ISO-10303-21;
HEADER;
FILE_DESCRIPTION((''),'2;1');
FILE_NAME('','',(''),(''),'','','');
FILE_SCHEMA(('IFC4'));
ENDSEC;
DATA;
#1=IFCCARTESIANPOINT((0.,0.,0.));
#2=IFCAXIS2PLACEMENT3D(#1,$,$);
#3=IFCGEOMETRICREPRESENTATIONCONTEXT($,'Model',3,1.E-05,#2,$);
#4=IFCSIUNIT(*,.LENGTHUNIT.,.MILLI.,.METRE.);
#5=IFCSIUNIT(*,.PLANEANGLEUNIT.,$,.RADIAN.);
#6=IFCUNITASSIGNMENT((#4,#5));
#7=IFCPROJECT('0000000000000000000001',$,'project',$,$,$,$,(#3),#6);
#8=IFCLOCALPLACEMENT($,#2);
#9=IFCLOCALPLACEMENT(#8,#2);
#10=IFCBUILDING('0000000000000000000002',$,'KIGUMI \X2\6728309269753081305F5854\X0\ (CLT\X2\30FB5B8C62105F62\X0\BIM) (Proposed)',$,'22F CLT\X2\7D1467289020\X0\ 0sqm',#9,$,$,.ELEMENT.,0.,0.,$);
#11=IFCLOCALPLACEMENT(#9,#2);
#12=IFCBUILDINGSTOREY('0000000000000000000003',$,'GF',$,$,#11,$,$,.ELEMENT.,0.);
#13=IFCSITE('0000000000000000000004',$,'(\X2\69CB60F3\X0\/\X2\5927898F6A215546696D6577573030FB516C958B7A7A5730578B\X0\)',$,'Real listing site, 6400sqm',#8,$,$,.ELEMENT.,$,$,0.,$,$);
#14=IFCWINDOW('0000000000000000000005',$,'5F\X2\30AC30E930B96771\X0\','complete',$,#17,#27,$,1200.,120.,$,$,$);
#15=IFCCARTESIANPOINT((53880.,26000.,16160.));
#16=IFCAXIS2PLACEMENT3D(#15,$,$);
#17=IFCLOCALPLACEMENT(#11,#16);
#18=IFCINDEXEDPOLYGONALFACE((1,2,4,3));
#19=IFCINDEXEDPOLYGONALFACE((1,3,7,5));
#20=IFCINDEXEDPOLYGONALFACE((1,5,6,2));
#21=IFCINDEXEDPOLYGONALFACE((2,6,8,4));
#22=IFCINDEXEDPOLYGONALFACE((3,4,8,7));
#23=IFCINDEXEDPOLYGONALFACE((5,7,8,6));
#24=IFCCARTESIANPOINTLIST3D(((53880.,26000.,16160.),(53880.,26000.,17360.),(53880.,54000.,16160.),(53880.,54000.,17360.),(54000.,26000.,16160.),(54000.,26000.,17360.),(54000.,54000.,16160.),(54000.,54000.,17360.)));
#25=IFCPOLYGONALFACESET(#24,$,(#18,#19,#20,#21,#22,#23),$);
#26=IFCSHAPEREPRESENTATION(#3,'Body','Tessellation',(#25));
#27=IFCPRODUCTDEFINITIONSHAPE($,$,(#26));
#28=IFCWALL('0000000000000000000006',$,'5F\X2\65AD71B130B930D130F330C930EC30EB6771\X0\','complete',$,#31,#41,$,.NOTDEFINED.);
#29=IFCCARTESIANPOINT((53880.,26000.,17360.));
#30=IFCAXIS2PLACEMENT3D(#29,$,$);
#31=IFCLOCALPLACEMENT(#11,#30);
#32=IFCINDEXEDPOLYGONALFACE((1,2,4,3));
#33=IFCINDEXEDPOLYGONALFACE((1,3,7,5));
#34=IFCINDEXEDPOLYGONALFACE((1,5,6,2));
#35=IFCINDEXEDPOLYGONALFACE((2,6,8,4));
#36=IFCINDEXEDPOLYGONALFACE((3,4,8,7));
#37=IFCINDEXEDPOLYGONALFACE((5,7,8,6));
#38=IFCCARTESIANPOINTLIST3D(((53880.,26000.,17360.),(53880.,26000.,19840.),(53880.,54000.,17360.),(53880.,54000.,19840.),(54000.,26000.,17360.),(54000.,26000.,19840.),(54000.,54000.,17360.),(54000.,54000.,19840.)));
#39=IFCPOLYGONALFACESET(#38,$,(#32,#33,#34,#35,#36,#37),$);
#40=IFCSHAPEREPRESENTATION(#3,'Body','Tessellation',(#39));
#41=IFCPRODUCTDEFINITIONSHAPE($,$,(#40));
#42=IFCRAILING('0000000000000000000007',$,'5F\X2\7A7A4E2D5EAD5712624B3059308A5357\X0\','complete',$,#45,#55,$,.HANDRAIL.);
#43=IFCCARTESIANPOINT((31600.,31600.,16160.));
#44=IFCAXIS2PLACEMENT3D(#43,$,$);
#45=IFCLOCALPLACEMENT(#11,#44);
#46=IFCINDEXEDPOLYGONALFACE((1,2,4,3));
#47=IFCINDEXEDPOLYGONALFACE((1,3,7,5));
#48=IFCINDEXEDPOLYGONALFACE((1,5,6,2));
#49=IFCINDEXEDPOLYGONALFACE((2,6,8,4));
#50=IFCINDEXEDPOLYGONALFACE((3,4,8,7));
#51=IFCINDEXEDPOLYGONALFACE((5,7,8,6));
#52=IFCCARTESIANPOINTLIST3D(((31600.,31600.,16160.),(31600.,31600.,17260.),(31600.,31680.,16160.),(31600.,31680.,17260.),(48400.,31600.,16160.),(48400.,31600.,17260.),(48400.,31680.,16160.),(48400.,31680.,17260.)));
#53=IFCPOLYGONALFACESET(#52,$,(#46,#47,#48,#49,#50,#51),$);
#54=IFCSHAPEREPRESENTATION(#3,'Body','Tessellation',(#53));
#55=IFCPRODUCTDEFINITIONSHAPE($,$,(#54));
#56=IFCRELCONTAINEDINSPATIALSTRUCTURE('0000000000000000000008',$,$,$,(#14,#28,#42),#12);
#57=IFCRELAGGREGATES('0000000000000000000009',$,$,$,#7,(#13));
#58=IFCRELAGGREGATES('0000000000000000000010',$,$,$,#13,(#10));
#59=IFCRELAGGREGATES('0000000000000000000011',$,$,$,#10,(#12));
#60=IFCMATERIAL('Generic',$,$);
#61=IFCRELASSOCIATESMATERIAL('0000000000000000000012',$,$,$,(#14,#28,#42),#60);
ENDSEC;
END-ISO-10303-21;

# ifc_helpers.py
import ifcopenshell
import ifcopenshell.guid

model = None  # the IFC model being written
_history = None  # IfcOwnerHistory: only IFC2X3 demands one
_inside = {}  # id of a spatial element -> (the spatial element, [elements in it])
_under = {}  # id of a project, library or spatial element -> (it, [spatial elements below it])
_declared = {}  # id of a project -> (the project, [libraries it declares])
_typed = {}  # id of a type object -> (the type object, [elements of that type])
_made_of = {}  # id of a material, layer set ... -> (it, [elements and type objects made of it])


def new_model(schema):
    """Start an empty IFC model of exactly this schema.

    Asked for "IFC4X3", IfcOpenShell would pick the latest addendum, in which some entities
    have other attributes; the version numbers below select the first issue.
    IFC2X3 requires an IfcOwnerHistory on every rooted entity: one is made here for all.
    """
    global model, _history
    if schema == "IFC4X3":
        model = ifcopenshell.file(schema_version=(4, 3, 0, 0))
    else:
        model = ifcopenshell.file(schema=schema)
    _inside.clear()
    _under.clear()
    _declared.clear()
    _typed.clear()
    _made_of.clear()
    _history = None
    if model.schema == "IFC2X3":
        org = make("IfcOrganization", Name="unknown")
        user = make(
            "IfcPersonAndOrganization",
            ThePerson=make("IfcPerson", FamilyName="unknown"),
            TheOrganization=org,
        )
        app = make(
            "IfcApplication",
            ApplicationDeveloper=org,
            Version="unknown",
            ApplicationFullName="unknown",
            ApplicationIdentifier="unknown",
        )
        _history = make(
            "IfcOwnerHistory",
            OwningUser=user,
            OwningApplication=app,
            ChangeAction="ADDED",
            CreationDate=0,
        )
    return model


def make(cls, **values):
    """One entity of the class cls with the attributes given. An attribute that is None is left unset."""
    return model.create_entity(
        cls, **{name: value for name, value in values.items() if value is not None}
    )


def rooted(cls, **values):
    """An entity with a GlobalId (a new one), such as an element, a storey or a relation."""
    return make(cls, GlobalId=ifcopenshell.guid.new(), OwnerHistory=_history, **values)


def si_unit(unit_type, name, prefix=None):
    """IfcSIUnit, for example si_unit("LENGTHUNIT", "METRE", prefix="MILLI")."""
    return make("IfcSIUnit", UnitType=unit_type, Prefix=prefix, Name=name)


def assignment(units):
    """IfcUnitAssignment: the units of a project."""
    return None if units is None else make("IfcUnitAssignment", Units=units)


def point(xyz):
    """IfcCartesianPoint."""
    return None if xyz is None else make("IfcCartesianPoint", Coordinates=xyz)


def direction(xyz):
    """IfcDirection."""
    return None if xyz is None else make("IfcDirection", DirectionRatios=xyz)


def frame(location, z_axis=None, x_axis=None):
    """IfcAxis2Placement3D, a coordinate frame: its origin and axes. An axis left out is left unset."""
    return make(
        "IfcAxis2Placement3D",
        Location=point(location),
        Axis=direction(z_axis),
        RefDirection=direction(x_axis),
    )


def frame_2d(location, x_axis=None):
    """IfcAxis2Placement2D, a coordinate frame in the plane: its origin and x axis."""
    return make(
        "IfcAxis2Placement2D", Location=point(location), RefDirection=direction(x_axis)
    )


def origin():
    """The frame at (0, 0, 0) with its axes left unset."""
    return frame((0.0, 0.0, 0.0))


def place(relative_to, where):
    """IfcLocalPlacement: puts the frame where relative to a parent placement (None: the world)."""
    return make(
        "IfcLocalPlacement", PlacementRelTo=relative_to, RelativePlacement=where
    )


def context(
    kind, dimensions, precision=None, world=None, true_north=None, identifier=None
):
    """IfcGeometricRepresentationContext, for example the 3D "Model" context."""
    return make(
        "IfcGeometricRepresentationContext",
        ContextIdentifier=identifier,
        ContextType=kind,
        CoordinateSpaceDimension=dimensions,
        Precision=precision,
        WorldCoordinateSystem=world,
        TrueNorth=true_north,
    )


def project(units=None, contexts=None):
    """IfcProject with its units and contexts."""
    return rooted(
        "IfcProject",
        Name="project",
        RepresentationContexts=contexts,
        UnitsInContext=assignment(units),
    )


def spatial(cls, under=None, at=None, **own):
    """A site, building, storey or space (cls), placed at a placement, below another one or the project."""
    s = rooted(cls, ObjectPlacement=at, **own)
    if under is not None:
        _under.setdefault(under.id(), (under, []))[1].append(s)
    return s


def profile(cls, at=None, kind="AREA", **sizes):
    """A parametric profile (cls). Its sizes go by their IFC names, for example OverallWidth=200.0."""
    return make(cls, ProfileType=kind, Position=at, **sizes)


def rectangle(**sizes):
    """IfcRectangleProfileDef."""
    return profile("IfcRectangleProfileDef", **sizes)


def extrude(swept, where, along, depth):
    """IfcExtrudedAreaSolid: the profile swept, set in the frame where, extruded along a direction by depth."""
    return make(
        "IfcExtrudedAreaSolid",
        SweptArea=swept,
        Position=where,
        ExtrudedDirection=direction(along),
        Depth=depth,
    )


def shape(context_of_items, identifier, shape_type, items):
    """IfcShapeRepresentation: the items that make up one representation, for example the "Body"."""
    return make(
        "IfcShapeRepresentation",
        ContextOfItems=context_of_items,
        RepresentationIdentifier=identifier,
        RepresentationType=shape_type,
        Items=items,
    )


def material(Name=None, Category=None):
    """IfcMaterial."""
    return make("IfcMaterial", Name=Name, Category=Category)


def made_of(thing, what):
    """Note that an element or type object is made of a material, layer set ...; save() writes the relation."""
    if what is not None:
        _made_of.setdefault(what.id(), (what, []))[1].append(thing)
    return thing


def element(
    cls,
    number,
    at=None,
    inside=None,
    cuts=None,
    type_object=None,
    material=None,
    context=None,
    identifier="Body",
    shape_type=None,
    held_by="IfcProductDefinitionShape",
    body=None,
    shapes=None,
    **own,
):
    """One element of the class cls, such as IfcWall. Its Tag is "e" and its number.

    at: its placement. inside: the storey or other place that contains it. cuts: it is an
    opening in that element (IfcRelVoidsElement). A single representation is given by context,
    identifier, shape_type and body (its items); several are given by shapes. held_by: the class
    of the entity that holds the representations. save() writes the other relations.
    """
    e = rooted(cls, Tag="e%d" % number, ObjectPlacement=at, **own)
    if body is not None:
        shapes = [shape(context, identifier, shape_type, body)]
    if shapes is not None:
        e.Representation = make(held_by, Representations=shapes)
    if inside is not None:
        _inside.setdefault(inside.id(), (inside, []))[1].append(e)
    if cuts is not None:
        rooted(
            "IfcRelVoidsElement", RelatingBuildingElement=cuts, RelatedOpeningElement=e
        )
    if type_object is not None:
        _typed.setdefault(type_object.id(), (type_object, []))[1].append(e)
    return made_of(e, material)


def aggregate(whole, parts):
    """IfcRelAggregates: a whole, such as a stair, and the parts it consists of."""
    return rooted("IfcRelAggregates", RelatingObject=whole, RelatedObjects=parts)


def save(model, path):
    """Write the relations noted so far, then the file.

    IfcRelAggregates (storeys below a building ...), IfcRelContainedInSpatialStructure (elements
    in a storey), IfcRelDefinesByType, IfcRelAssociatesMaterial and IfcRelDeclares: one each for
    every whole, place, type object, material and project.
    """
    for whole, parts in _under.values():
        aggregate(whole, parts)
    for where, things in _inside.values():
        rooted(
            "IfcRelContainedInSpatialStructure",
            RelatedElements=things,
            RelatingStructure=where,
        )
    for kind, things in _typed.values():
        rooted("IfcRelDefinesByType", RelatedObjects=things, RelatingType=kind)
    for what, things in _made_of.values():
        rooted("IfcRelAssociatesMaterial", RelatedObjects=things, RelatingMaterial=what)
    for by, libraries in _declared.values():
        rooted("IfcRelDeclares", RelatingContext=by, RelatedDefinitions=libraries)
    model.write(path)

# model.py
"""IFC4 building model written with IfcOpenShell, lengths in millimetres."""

from ifc_helpers import new_model, si_unit, frame, frame_2d, origin, place, context, project, spatial, rectangle, extrude, material, element, save


model = new_model("IFC4")

# Units and contexts
model_context = context("Model", 3, precision=1e-05, world=origin())
ifc_project = project(units=[si_unit("LENGTHUNIT", "METRE", prefix="MILLI"), si_unit("PLANEANGLEUNIT", "RADIAN")], contexts=[model_context])

# Site, building, storey
site_placement = place(None, origin())
site = spatial("IfcSite", under=ifc_project, at=site_placement, Name="(構想/大規模商業敷地・公開空地型)", ObjectType="Real listing site, 6400sqm", CompositionType="ELEMENT", RefElevation=0.0)
building_placement = place(site_placement, origin())
building = spatial("IfcBuilding", under=site, at=building_placement, Name="KIGUMI 木を極めた塔 (CLT・完成形BIM) (Proposed)", ObjectType="22F CLT純木造 0sqm", CompositionType="ELEMENT", ElevationOfRefHeight=0.0, ElevationOfTerrain=0.0)
storey_placement = place(building_placement, origin())
storey = spatial("IfcBuildingStorey", under=building, at=storey_placement, Name="GF", CompositionType="ELEMENT", Elevation=0.0)

# Shared definitions
ifc_material = material(Name="Generic")

# Window
window_1_placement = place(storey_placement, frame((53880.0, 26000.0, 16160.0)))
element("IfcWindow", 1, at=window_1_placement, inside=storey, material=ifc_material, Name="5Fガラス東", Description="complete", OverallHeight=1200.0, OverallWidth=120.0, context=model_context, shape_type="SweptSolid", body=[
    extrude(rectangle(XDim=120.0, YDim=28000.0, at=frame_2d((60.0, 14000.0))), frame((53880.0, 26000.0, 16160.0)), (0.0, 0.0, 1.0), 1200.0),
])

# Wall
wall_1_placement = place(storey_placement, frame((53880.0, 26000.0, 17360.0)))
element("IfcWall", 2, at=wall_1_placement, inside=storey, material=ifc_material, Name="5F断熱スパンドレル東", Description="complete", PredefinedType="NOTDEFINED", context=model_context, shape_type="SweptSolid", body=[
    extrude(rectangle(XDim=120.0, YDim=28000.0, at=frame_2d((60.0, 14000.0))), frame((53880.0, 26000.0, 17360.0)), (0.0, 0.0, 1.0), 2480.0),
])

# Railing
railing_placement = place(storey_placement, frame((31600.0, 31600.0, 16160.0)))
element("IfcRailing", 3, at=railing_placement, inside=storey, material=ifc_material, Name="5F空中庭園手すり南", Description="complete", PredefinedType="HANDRAIL", context=model_context, shape_type="SweptSolid", body=[
    extrude(rectangle(XDim=16800.0, YDim=80.0, at=frame_2d((8400.0, 40.0))), frame((31600.0, 31600.0, 16160.0)), (0.0, 0.0, 1.0), 1100.0),
])

save(model, "model.ifc")
